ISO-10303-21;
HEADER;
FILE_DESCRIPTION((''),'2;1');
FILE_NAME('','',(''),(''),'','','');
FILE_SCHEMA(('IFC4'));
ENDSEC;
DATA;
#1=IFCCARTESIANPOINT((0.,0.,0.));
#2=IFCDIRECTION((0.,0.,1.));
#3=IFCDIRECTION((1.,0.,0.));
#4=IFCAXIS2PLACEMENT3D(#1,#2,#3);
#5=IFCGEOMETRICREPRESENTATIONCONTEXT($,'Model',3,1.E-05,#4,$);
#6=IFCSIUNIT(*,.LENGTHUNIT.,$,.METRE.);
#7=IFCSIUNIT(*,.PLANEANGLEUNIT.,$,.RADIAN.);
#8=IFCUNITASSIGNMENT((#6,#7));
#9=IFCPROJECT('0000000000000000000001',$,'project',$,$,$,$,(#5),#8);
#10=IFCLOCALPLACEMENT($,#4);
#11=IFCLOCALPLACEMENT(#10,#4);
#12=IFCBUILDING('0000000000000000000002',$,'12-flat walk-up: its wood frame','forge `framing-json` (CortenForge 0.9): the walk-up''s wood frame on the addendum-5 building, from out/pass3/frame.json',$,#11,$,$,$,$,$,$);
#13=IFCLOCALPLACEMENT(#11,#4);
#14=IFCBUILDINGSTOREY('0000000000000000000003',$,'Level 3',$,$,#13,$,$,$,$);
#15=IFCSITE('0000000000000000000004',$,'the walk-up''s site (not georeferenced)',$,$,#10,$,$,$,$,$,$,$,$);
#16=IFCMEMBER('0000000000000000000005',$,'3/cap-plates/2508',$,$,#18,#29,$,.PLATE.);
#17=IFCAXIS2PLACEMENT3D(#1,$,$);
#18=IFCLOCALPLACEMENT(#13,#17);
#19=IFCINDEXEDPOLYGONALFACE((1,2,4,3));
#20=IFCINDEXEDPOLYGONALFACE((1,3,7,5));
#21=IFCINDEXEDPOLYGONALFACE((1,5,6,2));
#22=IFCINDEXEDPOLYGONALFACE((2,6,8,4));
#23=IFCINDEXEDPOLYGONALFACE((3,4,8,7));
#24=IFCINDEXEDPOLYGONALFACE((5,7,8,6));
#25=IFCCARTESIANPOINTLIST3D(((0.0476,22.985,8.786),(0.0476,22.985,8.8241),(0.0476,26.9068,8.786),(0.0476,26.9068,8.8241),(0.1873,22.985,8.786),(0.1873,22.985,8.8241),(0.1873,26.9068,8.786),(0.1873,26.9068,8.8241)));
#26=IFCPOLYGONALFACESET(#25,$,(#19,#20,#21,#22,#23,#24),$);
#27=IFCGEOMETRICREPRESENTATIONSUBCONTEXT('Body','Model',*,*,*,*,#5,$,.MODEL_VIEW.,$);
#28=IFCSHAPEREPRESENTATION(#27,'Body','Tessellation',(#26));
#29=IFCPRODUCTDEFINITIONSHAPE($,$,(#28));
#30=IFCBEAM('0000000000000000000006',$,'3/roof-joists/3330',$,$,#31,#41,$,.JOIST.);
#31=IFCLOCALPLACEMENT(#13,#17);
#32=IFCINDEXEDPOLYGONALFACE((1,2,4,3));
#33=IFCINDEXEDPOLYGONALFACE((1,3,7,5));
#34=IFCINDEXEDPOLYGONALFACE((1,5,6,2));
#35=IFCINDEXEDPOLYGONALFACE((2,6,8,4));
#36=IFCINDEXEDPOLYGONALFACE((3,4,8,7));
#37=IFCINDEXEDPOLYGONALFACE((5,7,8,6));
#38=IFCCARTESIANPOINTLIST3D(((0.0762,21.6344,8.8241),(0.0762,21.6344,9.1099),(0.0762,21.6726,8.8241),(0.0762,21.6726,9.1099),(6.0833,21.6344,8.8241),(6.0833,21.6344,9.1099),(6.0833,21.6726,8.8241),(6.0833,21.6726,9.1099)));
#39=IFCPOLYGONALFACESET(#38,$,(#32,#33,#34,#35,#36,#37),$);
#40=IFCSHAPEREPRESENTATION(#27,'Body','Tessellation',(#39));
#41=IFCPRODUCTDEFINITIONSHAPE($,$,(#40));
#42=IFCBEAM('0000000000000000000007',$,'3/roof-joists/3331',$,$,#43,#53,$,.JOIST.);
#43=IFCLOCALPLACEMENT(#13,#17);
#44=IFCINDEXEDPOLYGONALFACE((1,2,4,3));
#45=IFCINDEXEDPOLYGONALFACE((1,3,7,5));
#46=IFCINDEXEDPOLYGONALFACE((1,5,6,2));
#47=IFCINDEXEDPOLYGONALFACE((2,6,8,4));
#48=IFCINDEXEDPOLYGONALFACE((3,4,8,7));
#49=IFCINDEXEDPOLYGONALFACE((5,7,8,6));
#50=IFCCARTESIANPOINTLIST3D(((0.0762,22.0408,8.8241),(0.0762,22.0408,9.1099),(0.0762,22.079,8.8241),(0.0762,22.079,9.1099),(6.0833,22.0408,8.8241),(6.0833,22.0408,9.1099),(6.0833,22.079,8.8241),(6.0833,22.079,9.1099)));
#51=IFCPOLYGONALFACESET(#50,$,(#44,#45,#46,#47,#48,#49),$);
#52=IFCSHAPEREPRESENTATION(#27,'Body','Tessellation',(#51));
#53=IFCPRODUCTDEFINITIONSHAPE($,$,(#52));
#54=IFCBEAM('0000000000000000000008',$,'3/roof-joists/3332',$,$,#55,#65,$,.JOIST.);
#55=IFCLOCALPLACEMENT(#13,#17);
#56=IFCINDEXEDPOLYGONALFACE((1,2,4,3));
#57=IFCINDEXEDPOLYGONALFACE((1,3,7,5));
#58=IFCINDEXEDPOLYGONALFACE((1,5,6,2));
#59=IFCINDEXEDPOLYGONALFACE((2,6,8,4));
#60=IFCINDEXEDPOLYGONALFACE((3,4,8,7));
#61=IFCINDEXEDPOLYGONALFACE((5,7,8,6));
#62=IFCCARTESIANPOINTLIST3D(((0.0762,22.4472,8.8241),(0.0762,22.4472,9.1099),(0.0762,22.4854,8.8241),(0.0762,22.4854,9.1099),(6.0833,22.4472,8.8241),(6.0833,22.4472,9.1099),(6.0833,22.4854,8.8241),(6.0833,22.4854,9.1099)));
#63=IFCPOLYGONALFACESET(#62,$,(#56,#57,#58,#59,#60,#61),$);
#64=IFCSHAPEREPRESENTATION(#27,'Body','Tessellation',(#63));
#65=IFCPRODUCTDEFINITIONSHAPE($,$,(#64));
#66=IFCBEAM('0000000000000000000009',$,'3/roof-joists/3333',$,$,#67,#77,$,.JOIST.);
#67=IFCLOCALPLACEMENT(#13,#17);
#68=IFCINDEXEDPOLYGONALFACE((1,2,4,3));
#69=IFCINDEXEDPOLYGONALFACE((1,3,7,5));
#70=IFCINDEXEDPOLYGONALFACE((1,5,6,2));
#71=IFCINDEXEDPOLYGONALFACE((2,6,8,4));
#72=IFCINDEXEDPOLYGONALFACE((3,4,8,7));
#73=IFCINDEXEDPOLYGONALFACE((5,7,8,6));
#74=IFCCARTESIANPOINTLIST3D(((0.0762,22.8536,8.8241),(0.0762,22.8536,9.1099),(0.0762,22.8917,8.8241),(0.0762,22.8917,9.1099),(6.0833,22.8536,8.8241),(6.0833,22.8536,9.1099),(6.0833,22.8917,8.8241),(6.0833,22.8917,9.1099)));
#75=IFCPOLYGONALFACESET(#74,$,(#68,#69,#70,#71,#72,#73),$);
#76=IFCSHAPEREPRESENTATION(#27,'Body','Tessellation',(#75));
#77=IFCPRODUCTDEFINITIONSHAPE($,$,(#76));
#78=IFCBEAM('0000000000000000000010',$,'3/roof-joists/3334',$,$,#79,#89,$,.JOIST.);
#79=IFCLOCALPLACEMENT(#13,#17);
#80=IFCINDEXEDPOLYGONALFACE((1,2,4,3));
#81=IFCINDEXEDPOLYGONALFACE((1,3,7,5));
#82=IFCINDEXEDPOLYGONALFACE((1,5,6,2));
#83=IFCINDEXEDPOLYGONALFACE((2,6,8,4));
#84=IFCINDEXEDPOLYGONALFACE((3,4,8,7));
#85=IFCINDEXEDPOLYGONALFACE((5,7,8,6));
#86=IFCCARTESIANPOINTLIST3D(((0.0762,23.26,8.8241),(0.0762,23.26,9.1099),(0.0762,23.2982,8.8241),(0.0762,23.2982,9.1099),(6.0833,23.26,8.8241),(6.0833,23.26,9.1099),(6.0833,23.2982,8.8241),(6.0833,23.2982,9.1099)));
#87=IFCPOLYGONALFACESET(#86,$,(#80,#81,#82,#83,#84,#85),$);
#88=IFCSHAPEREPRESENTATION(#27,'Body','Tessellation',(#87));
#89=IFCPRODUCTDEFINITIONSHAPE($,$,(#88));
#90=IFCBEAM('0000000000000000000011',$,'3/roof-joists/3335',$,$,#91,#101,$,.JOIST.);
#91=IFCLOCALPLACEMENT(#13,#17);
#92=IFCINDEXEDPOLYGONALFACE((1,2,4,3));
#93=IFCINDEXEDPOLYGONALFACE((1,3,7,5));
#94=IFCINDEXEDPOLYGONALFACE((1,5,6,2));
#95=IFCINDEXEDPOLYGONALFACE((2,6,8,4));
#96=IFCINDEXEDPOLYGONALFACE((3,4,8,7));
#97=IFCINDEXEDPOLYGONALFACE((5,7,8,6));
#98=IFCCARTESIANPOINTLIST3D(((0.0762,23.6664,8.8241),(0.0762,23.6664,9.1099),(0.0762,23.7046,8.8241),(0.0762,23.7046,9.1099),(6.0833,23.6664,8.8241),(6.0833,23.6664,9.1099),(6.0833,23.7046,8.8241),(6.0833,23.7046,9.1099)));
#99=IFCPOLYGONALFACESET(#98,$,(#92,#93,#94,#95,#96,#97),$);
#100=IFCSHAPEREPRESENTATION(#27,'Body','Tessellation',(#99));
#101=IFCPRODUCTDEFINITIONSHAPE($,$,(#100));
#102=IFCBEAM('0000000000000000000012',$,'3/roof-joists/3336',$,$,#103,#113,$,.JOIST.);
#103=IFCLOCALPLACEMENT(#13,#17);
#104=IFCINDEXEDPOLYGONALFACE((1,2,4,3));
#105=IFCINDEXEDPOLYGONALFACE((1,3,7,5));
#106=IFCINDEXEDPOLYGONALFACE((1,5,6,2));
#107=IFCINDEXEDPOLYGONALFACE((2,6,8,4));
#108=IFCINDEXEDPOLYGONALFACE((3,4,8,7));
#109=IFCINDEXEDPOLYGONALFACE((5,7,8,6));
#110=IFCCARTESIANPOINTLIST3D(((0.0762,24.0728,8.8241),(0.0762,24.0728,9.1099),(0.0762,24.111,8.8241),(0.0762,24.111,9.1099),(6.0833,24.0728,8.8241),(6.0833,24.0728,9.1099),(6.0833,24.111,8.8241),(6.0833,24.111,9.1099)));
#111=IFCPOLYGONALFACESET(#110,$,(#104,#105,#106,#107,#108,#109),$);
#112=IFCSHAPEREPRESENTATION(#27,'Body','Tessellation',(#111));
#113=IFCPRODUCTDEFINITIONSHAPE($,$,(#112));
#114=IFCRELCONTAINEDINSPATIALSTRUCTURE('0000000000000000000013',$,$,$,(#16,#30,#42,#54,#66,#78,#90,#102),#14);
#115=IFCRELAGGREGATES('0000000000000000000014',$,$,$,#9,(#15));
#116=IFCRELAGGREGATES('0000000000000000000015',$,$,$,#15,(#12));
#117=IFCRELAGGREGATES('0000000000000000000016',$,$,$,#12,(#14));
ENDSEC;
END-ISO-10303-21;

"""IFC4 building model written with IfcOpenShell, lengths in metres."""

from ifc_helpers import new_model, si_unit, frame, frame_2d, origin, origin_with_axes, place, context, subcontext, project, spatial, rectangle, extrude, element, save


model = new_model("IFC4")

# Units and contexts
model_context = context("Model", 3, precision=1e-05, world=origin_with_axes())
body_context = subcontext(model_context, "Body", "Model", "MODEL_VIEW")
ifc_project = project(units=[si_unit("LENGTHUNIT", "METRE"), si_unit("PLANEANGLEUNIT", "RADIAN")], contexts=[model_context])

# Site, building, storey
site_placement = place(None, origin_with_axes())
site = spatial("IfcSite", under=ifc_project, at=site_placement, Name="the walk-up's site (not georeferenced)")
building_placement = place(site_placement, origin_with_axes())
building = spatial("IfcBuilding", under=site, at=building_placement, Name="12-flat walk-up: its wood frame", Description="forge `framing-json` (CortenForge 0.9): the walk-up's wood frame on the addendum-5 building, from out/pass3/frame.json")
storey_placement = place(building_placement, origin_with_axes())
storey = spatial("IfcBuildingStorey", under=building, at=storey_placement, Name="Level 3")

# Member
member_1_placement = place(storey_placement, frame((0.0476, 22.985, 8.786), z_axis=(0.0, 0.0, 1.0), x_axis=(1.0, 0.0, 0.0)))
element("IfcMember", 1, at=member_1_placement, inside=storey, Name="3/cap-plates/2508", PredefinedType="PLATE", context=body_context, shape_type="SweptSolid", body=[
    extrude(rectangle(XDim=0.1397, YDim=3.9218, at=frame_2d((0.0698, 1.9609))), origin(), (0.0, 0.0, 1.0), 0.0381),
])

# Beams
for number, where, z_axis, x_axis, name in (
    (2, (0.0762, 21.6345, 8.8241), (0.0, 0.0, 1.0), (1.0, 0.0, 0.0), "3/roof-joists/3330"),
    (3, (0.0762, 22.0408, 8.8241), (0.0, 0.0, 1.0), (1.0, 0.0, 0.0), "3/roof-joists/3331"),
    (4, (0.0762, 22.4473, 8.8241), (0.0, 0.0, 1.0), (1.0, 0.0, 0.0), "3/roof-joists/3332"),
    (5, (0.0762, 22.8536, 8.8241), (0.0, 0.0, 1.0), (1.0, 0.0, 0.0), "3/roof-joists/3333"),
    (6, (0.0762, 23.26, 8.8241), (0.0, 0.0, 1.0), (1.0, 0.0, 0.0), "3/roof-joists/3334"),
    (7, (0.0762, 23.6665, 8.8241), (0.0, 0.0, 1.0), (1.0, 0.0, 0.0), "3/roof-joists/3335"),
    (8, (0.0762, 24.0728, 8.8241), (0.0, 0.0, 1.0), (1.0, 0.0, 0.0), "3/roof-joists/3336"),
):
    element("IfcBeam", number, at=place(storey_placement, frame(where, z_axis=z_axis, x_axis=x_axis)), inside=storey, Name=name, PredefinedType="JOIST", context=body_context, shape_type="SweptSolid", body=[
        extrude(rectangle(XDim=6.0071, YDim=0.0381, at=frame_2d((3.0036, 0.0191))), origin(), (0.0, 0.0, 1.0), 0.2858),
    ])

save(model, "model.ifc")
